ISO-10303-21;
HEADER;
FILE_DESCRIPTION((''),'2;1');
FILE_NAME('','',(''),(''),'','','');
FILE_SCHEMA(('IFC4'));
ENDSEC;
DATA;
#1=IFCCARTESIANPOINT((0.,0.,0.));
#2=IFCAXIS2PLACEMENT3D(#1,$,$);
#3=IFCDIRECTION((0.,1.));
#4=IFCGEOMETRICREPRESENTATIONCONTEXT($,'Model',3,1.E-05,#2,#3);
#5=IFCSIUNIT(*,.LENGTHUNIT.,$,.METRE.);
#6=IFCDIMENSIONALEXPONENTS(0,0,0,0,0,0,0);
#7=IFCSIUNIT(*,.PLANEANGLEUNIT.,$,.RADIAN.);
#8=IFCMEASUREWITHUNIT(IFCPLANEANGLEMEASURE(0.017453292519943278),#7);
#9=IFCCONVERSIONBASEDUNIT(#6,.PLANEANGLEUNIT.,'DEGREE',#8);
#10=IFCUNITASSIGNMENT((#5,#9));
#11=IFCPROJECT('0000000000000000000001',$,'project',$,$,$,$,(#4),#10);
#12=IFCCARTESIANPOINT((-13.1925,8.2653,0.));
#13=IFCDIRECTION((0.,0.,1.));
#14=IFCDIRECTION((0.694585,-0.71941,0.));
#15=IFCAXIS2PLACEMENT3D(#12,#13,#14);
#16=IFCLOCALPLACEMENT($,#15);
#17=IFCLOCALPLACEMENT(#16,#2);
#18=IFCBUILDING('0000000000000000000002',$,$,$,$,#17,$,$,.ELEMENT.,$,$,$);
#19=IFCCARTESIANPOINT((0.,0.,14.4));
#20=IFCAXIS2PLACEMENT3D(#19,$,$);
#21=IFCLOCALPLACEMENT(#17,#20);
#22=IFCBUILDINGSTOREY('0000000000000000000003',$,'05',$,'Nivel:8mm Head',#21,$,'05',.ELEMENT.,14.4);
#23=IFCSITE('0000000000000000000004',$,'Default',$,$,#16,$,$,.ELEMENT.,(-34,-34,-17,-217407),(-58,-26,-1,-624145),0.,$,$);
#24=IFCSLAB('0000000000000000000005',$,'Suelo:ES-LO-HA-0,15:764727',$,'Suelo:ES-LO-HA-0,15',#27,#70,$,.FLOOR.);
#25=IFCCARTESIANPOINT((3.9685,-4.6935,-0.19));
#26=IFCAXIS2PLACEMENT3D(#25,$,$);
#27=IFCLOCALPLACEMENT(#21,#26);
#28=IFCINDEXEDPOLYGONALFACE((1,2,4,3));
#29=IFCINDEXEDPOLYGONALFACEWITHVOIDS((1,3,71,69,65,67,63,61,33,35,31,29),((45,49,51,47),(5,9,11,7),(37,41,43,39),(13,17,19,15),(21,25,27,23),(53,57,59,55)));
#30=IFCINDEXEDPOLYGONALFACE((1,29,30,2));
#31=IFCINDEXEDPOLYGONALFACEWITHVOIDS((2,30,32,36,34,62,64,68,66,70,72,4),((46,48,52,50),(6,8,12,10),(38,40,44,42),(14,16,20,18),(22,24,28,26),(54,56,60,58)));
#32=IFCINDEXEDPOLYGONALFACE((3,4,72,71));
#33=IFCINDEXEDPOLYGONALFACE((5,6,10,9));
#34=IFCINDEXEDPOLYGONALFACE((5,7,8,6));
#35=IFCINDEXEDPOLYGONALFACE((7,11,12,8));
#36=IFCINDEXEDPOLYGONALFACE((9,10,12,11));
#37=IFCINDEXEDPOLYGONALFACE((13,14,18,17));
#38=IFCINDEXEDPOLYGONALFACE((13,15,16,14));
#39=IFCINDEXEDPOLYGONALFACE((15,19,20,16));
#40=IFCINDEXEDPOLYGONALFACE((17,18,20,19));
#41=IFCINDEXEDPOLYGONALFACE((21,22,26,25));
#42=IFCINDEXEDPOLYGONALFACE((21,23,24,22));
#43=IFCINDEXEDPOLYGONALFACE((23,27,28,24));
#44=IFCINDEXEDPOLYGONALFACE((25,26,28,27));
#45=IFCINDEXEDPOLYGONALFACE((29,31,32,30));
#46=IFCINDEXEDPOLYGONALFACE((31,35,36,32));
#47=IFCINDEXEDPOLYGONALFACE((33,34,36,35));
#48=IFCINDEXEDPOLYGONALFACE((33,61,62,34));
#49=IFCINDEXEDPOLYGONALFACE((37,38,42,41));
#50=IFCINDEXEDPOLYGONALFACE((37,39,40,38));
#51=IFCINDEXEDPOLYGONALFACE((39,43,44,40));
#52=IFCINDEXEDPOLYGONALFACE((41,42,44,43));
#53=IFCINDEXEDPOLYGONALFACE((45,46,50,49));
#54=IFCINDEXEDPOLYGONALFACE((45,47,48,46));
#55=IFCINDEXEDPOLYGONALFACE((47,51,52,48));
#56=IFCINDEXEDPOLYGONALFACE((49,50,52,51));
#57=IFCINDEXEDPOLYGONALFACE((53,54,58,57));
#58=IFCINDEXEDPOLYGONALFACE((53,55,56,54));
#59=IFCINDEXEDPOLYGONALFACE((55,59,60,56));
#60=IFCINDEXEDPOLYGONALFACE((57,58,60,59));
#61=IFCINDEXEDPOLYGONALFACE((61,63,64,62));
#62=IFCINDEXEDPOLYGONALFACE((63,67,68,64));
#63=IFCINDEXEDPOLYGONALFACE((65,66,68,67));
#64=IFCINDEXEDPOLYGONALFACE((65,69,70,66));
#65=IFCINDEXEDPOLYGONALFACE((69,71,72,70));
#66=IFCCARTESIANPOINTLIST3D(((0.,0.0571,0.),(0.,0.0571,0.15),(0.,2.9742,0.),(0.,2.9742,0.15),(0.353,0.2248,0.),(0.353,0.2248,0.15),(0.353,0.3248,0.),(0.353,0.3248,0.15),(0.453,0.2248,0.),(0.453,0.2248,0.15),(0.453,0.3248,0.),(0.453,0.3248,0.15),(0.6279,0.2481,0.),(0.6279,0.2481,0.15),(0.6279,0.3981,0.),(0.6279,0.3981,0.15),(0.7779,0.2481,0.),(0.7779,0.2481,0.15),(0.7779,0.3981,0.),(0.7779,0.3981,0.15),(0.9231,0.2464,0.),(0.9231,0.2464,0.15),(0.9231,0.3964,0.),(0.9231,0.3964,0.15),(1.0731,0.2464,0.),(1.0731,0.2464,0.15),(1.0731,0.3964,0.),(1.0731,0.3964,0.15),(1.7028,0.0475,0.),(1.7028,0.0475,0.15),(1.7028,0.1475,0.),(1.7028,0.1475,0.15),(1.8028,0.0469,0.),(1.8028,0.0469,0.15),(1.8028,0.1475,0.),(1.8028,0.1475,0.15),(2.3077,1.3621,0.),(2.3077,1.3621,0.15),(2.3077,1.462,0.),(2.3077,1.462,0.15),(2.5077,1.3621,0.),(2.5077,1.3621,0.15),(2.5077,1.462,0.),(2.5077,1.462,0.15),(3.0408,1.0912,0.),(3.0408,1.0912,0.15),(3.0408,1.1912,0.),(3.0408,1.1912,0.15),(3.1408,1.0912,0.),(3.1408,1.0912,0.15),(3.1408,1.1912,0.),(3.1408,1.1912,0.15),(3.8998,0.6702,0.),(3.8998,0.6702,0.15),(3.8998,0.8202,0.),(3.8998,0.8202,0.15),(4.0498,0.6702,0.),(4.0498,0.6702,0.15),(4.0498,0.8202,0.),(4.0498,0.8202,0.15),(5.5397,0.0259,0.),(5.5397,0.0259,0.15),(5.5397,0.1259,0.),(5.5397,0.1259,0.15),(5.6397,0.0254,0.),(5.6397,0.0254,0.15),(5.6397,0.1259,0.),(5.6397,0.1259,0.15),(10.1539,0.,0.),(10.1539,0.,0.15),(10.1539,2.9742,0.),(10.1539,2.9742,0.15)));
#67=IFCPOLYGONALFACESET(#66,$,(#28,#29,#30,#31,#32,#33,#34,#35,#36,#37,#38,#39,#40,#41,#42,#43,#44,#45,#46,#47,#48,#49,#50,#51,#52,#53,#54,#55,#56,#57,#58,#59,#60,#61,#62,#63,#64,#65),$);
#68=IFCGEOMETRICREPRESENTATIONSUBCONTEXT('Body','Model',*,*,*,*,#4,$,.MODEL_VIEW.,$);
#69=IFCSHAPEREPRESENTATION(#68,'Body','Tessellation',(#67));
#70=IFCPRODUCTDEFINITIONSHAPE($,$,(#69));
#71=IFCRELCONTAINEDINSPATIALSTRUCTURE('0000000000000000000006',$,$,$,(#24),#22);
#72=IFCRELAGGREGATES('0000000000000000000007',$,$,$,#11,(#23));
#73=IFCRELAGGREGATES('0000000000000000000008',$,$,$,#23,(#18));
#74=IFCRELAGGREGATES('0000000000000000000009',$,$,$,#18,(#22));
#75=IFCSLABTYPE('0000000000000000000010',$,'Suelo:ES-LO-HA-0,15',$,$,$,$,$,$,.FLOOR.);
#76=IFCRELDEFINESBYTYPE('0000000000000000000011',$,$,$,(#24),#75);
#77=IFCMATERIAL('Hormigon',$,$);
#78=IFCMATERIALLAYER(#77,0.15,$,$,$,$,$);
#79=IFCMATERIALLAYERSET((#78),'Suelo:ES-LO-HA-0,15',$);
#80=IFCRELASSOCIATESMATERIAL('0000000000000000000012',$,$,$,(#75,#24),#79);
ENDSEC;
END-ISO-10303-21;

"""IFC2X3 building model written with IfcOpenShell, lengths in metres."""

from ifc_helpers import new_model, entity, si_unit, converted_unit, direction, frame, frame_2d, origin, origin_2d_with_axis, place, context, subcontext, project, spatial, polyline, rectangle, outline, extrude, material, layer, layer_set, layer_usage, type_object, element, save


model = new_model("IFC2X3")

# Units and contexts
model_context = context("Model", 3, precision=1e-05, world=origin(), true_north=direction((0.0, 1.0)))
body_context = subcontext(model_context, "Body", "Model", "MODEL_VIEW")
ifc_project = project(units=[si_unit("LENGTHUNIT", "METRE"), converted_unit("PLANEANGLEUNIT", "DEGREE", entity("IfcPlaneAngleMeasure", 0.017453292519943278), si_unit("PLANEANGLEUNIT", "RADIAN"), dimensions=[0, 0, 0, 0, 0, 0, 0])], contexts=[model_context])

# Site, building, storey
site_placement = place(None, frame((-13.1925, 8.2653, 0.0), z_axis=(0.0, 0.0, 1.0), x_axis=(0.694585, -0.71941, 0.0)))
site = spatial("IfcSite", under=ifc_project, at=site_placement, Name="Default", CompositionType="ELEMENT", RefLatitude=(-34, -34, -17, -217407), RefLongitude=(-58, -26, -1, -624145), RefElevation=0.0)
building_placement = place(site_placement, origin())
building = spatial("IfcBuilding", under=site, at=building_placement, CompositionType="ELEMENT")
storey_placement = place(building_placement, frame((0.0, 0.0, 14.4)))
storey = spatial("IfcBuildingStorey", under=building, at=storey_placement, Name="05", ObjectType="Nivel:8mm Head", LongName="05", CompositionType="ELEMENT", Elevation=14.4)

# Slab, openings
ifc_material_1 = material(Name="Hormigon")
ifc_layer_1 = layer(ifc_material_1, 0.15)
ifc_layer_set_1 = layer_set([ifc_layer_1], Name="Suelo:ES-LO-HA-0,15")
slab_type = type_object("IfcSlabType", Name="Suelo:ES-LO-HA-0,15", PredefinedType="FLOOR", material=ifc_layer_set_1)
ifc_layer_usage_1 = layer_usage(ifc_layer_set_1, "AXIS3", "POSITIVE", 0.0)
slab_1_placement = place(storey_placement, frame((3.9685, -4.6935, -0.19)))
slab_1 = element("IfcSlab", 1, at=slab_1_placement, inside=storey, type_object=slab_type, material=ifc_layer_usage_1, Name="Suelo:ES-LO-HA-0,15:764727", ObjectType="Suelo:ES-LO-HA-0,15", PredefinedType="FLOOR", context=body_context, shape_type="SweptSolid", body=[
    extrude(outline(polyline([(-5.077, 1.4871), (-5.077, -1.4871), (-0.5627, -1.4617), (-0.5627, -1.3612), (-0.4627, -1.3612), (-0.4627, -1.4612), (3.2742, -1.4402), (3.2742, -1.3396), (3.3742, -1.3396), (3.3742, -1.4396), (5.077, -1.43), (5.077, 1.4871), (-5.077, 1.4871)])), frame((5.077, 1.4871, 0.15), z_axis=(0.0, 0.0, -1.0), x_axis=(-1.0, 0.0, 0.0)), (0.0, 0.0, 1.0), 0.15),
])
opening_1_placement = place(slab_1_placement, origin())
element("IfcOpeningElement", 2, at=opening_1_placement, cuts=slab_1, ObjectType="Opening", context=body_context, shape_type="SweptSolid", body=[
    extrude(rectangle(XDim=0.1, YDim=0.2, at=origin_2d_with_axis()), frame((2.4077, 1.412, 0.15), z_axis=(0.0, 0.0, -1.0), x_axis=(0.0, -1.0, 0.0)), (0.0, 0.0, 1.0), 0.15),
])
opening_2_placement = place(slab_1_placement, origin())
element("IfcOpeningElement", 3, at=opening_2_placement, cuts=slab_1, ObjectType="Opening", context=body_context, shape_type="SweptSolid", body=[
    extrude(rectangle(XDim=0.1, YDim=0.1, at=frame_2d((0.0, 0.0), x_axis=(1.0, 0.0))), frame((3.0908, 1.1412, 0.15), z_axis=(0.0, 0.0, -1.0), x_axis=(0.0, -1.0, 0.0)), (0.0, 0.0, 1.0), 0.15),
])
opening_3_placement = place(slab_1_placement, origin())
element("IfcOpeningElement", 4, at=opening_3_placement, cuts=slab_1, ObjectType="Opening", context=body_context, shape_type="SweptSolid", body=[
    extrude(rectangle(XDim=0.15, YDim=0.15, at=frame_2d((0.0, 0.0), x_axis=(1.0, 0.0))), frame((3.9748, 0.7452, 0.15), z_axis=(0.0, 0.0, -1.0), x_axis=(0.0, -1.0, 0.0)), (0.0, 0.0, 1.0), 0.15),
])
opening_4_placement = place(slab_1_placement, origin())
element("IfcOpeningElement", 5, at=opening_4_placement, cuts=slab_1, ObjectType="Opening", context=body_context, shape_type="SweptSolid", body=[
    extrude(rectangle(XDim=0.15, YDim=0.15, at=frame_2d((0.0, 0.0), x_axis=(1.0, 0.0))), frame((0.9981, 0.3214, 0.15), z_axis=(0.0, 0.0, -1.0), x_axis=(0.0, -1.0, 0.0)), (0.0, 0.0, 1.0), 0.15),
])
opening_5_placement = place(slab_1_placement, origin())
element("IfcOpeningElement", 6, at=opening_5_placement, cuts=slab_1, ObjectType="Opening", context=body_context, shape_type="SweptSolid", body=[
    extrude(rectangle(XDim=0.15, YDim=0.15, at=frame_2d((0.0, 0.0), x_axis=(1.0, 0.0))), frame((0.7029, 0.3231, 0.15), z_axis=(0.0, 0.0, 1.0), x_axis=(0.0, -1.0, 0.0)), (0.0, 0.0, -1.0), 0.15),
])
opening_6_placement = place(slab_1_placement, origin())
element("IfcOpeningElement", 7, at=opening_6_placement, cuts=slab_1, ObjectType="Opening", context=body_context, shape_type="SweptSolid", body=[
    extrude(rectangle(XDim=0.1, YDim=0.1, at=frame_2d((0.0, 0.0), x_axis=(1.0, 0.0))), frame((0.403, 0.2748, 0.15), z_axis=(0.0, 0.0, -1.0), x_axis=(0.0, -1.0, 0.0)), (0.0, 0.0, 1.0), 0.15),
])

save(model, "model.ifc")
